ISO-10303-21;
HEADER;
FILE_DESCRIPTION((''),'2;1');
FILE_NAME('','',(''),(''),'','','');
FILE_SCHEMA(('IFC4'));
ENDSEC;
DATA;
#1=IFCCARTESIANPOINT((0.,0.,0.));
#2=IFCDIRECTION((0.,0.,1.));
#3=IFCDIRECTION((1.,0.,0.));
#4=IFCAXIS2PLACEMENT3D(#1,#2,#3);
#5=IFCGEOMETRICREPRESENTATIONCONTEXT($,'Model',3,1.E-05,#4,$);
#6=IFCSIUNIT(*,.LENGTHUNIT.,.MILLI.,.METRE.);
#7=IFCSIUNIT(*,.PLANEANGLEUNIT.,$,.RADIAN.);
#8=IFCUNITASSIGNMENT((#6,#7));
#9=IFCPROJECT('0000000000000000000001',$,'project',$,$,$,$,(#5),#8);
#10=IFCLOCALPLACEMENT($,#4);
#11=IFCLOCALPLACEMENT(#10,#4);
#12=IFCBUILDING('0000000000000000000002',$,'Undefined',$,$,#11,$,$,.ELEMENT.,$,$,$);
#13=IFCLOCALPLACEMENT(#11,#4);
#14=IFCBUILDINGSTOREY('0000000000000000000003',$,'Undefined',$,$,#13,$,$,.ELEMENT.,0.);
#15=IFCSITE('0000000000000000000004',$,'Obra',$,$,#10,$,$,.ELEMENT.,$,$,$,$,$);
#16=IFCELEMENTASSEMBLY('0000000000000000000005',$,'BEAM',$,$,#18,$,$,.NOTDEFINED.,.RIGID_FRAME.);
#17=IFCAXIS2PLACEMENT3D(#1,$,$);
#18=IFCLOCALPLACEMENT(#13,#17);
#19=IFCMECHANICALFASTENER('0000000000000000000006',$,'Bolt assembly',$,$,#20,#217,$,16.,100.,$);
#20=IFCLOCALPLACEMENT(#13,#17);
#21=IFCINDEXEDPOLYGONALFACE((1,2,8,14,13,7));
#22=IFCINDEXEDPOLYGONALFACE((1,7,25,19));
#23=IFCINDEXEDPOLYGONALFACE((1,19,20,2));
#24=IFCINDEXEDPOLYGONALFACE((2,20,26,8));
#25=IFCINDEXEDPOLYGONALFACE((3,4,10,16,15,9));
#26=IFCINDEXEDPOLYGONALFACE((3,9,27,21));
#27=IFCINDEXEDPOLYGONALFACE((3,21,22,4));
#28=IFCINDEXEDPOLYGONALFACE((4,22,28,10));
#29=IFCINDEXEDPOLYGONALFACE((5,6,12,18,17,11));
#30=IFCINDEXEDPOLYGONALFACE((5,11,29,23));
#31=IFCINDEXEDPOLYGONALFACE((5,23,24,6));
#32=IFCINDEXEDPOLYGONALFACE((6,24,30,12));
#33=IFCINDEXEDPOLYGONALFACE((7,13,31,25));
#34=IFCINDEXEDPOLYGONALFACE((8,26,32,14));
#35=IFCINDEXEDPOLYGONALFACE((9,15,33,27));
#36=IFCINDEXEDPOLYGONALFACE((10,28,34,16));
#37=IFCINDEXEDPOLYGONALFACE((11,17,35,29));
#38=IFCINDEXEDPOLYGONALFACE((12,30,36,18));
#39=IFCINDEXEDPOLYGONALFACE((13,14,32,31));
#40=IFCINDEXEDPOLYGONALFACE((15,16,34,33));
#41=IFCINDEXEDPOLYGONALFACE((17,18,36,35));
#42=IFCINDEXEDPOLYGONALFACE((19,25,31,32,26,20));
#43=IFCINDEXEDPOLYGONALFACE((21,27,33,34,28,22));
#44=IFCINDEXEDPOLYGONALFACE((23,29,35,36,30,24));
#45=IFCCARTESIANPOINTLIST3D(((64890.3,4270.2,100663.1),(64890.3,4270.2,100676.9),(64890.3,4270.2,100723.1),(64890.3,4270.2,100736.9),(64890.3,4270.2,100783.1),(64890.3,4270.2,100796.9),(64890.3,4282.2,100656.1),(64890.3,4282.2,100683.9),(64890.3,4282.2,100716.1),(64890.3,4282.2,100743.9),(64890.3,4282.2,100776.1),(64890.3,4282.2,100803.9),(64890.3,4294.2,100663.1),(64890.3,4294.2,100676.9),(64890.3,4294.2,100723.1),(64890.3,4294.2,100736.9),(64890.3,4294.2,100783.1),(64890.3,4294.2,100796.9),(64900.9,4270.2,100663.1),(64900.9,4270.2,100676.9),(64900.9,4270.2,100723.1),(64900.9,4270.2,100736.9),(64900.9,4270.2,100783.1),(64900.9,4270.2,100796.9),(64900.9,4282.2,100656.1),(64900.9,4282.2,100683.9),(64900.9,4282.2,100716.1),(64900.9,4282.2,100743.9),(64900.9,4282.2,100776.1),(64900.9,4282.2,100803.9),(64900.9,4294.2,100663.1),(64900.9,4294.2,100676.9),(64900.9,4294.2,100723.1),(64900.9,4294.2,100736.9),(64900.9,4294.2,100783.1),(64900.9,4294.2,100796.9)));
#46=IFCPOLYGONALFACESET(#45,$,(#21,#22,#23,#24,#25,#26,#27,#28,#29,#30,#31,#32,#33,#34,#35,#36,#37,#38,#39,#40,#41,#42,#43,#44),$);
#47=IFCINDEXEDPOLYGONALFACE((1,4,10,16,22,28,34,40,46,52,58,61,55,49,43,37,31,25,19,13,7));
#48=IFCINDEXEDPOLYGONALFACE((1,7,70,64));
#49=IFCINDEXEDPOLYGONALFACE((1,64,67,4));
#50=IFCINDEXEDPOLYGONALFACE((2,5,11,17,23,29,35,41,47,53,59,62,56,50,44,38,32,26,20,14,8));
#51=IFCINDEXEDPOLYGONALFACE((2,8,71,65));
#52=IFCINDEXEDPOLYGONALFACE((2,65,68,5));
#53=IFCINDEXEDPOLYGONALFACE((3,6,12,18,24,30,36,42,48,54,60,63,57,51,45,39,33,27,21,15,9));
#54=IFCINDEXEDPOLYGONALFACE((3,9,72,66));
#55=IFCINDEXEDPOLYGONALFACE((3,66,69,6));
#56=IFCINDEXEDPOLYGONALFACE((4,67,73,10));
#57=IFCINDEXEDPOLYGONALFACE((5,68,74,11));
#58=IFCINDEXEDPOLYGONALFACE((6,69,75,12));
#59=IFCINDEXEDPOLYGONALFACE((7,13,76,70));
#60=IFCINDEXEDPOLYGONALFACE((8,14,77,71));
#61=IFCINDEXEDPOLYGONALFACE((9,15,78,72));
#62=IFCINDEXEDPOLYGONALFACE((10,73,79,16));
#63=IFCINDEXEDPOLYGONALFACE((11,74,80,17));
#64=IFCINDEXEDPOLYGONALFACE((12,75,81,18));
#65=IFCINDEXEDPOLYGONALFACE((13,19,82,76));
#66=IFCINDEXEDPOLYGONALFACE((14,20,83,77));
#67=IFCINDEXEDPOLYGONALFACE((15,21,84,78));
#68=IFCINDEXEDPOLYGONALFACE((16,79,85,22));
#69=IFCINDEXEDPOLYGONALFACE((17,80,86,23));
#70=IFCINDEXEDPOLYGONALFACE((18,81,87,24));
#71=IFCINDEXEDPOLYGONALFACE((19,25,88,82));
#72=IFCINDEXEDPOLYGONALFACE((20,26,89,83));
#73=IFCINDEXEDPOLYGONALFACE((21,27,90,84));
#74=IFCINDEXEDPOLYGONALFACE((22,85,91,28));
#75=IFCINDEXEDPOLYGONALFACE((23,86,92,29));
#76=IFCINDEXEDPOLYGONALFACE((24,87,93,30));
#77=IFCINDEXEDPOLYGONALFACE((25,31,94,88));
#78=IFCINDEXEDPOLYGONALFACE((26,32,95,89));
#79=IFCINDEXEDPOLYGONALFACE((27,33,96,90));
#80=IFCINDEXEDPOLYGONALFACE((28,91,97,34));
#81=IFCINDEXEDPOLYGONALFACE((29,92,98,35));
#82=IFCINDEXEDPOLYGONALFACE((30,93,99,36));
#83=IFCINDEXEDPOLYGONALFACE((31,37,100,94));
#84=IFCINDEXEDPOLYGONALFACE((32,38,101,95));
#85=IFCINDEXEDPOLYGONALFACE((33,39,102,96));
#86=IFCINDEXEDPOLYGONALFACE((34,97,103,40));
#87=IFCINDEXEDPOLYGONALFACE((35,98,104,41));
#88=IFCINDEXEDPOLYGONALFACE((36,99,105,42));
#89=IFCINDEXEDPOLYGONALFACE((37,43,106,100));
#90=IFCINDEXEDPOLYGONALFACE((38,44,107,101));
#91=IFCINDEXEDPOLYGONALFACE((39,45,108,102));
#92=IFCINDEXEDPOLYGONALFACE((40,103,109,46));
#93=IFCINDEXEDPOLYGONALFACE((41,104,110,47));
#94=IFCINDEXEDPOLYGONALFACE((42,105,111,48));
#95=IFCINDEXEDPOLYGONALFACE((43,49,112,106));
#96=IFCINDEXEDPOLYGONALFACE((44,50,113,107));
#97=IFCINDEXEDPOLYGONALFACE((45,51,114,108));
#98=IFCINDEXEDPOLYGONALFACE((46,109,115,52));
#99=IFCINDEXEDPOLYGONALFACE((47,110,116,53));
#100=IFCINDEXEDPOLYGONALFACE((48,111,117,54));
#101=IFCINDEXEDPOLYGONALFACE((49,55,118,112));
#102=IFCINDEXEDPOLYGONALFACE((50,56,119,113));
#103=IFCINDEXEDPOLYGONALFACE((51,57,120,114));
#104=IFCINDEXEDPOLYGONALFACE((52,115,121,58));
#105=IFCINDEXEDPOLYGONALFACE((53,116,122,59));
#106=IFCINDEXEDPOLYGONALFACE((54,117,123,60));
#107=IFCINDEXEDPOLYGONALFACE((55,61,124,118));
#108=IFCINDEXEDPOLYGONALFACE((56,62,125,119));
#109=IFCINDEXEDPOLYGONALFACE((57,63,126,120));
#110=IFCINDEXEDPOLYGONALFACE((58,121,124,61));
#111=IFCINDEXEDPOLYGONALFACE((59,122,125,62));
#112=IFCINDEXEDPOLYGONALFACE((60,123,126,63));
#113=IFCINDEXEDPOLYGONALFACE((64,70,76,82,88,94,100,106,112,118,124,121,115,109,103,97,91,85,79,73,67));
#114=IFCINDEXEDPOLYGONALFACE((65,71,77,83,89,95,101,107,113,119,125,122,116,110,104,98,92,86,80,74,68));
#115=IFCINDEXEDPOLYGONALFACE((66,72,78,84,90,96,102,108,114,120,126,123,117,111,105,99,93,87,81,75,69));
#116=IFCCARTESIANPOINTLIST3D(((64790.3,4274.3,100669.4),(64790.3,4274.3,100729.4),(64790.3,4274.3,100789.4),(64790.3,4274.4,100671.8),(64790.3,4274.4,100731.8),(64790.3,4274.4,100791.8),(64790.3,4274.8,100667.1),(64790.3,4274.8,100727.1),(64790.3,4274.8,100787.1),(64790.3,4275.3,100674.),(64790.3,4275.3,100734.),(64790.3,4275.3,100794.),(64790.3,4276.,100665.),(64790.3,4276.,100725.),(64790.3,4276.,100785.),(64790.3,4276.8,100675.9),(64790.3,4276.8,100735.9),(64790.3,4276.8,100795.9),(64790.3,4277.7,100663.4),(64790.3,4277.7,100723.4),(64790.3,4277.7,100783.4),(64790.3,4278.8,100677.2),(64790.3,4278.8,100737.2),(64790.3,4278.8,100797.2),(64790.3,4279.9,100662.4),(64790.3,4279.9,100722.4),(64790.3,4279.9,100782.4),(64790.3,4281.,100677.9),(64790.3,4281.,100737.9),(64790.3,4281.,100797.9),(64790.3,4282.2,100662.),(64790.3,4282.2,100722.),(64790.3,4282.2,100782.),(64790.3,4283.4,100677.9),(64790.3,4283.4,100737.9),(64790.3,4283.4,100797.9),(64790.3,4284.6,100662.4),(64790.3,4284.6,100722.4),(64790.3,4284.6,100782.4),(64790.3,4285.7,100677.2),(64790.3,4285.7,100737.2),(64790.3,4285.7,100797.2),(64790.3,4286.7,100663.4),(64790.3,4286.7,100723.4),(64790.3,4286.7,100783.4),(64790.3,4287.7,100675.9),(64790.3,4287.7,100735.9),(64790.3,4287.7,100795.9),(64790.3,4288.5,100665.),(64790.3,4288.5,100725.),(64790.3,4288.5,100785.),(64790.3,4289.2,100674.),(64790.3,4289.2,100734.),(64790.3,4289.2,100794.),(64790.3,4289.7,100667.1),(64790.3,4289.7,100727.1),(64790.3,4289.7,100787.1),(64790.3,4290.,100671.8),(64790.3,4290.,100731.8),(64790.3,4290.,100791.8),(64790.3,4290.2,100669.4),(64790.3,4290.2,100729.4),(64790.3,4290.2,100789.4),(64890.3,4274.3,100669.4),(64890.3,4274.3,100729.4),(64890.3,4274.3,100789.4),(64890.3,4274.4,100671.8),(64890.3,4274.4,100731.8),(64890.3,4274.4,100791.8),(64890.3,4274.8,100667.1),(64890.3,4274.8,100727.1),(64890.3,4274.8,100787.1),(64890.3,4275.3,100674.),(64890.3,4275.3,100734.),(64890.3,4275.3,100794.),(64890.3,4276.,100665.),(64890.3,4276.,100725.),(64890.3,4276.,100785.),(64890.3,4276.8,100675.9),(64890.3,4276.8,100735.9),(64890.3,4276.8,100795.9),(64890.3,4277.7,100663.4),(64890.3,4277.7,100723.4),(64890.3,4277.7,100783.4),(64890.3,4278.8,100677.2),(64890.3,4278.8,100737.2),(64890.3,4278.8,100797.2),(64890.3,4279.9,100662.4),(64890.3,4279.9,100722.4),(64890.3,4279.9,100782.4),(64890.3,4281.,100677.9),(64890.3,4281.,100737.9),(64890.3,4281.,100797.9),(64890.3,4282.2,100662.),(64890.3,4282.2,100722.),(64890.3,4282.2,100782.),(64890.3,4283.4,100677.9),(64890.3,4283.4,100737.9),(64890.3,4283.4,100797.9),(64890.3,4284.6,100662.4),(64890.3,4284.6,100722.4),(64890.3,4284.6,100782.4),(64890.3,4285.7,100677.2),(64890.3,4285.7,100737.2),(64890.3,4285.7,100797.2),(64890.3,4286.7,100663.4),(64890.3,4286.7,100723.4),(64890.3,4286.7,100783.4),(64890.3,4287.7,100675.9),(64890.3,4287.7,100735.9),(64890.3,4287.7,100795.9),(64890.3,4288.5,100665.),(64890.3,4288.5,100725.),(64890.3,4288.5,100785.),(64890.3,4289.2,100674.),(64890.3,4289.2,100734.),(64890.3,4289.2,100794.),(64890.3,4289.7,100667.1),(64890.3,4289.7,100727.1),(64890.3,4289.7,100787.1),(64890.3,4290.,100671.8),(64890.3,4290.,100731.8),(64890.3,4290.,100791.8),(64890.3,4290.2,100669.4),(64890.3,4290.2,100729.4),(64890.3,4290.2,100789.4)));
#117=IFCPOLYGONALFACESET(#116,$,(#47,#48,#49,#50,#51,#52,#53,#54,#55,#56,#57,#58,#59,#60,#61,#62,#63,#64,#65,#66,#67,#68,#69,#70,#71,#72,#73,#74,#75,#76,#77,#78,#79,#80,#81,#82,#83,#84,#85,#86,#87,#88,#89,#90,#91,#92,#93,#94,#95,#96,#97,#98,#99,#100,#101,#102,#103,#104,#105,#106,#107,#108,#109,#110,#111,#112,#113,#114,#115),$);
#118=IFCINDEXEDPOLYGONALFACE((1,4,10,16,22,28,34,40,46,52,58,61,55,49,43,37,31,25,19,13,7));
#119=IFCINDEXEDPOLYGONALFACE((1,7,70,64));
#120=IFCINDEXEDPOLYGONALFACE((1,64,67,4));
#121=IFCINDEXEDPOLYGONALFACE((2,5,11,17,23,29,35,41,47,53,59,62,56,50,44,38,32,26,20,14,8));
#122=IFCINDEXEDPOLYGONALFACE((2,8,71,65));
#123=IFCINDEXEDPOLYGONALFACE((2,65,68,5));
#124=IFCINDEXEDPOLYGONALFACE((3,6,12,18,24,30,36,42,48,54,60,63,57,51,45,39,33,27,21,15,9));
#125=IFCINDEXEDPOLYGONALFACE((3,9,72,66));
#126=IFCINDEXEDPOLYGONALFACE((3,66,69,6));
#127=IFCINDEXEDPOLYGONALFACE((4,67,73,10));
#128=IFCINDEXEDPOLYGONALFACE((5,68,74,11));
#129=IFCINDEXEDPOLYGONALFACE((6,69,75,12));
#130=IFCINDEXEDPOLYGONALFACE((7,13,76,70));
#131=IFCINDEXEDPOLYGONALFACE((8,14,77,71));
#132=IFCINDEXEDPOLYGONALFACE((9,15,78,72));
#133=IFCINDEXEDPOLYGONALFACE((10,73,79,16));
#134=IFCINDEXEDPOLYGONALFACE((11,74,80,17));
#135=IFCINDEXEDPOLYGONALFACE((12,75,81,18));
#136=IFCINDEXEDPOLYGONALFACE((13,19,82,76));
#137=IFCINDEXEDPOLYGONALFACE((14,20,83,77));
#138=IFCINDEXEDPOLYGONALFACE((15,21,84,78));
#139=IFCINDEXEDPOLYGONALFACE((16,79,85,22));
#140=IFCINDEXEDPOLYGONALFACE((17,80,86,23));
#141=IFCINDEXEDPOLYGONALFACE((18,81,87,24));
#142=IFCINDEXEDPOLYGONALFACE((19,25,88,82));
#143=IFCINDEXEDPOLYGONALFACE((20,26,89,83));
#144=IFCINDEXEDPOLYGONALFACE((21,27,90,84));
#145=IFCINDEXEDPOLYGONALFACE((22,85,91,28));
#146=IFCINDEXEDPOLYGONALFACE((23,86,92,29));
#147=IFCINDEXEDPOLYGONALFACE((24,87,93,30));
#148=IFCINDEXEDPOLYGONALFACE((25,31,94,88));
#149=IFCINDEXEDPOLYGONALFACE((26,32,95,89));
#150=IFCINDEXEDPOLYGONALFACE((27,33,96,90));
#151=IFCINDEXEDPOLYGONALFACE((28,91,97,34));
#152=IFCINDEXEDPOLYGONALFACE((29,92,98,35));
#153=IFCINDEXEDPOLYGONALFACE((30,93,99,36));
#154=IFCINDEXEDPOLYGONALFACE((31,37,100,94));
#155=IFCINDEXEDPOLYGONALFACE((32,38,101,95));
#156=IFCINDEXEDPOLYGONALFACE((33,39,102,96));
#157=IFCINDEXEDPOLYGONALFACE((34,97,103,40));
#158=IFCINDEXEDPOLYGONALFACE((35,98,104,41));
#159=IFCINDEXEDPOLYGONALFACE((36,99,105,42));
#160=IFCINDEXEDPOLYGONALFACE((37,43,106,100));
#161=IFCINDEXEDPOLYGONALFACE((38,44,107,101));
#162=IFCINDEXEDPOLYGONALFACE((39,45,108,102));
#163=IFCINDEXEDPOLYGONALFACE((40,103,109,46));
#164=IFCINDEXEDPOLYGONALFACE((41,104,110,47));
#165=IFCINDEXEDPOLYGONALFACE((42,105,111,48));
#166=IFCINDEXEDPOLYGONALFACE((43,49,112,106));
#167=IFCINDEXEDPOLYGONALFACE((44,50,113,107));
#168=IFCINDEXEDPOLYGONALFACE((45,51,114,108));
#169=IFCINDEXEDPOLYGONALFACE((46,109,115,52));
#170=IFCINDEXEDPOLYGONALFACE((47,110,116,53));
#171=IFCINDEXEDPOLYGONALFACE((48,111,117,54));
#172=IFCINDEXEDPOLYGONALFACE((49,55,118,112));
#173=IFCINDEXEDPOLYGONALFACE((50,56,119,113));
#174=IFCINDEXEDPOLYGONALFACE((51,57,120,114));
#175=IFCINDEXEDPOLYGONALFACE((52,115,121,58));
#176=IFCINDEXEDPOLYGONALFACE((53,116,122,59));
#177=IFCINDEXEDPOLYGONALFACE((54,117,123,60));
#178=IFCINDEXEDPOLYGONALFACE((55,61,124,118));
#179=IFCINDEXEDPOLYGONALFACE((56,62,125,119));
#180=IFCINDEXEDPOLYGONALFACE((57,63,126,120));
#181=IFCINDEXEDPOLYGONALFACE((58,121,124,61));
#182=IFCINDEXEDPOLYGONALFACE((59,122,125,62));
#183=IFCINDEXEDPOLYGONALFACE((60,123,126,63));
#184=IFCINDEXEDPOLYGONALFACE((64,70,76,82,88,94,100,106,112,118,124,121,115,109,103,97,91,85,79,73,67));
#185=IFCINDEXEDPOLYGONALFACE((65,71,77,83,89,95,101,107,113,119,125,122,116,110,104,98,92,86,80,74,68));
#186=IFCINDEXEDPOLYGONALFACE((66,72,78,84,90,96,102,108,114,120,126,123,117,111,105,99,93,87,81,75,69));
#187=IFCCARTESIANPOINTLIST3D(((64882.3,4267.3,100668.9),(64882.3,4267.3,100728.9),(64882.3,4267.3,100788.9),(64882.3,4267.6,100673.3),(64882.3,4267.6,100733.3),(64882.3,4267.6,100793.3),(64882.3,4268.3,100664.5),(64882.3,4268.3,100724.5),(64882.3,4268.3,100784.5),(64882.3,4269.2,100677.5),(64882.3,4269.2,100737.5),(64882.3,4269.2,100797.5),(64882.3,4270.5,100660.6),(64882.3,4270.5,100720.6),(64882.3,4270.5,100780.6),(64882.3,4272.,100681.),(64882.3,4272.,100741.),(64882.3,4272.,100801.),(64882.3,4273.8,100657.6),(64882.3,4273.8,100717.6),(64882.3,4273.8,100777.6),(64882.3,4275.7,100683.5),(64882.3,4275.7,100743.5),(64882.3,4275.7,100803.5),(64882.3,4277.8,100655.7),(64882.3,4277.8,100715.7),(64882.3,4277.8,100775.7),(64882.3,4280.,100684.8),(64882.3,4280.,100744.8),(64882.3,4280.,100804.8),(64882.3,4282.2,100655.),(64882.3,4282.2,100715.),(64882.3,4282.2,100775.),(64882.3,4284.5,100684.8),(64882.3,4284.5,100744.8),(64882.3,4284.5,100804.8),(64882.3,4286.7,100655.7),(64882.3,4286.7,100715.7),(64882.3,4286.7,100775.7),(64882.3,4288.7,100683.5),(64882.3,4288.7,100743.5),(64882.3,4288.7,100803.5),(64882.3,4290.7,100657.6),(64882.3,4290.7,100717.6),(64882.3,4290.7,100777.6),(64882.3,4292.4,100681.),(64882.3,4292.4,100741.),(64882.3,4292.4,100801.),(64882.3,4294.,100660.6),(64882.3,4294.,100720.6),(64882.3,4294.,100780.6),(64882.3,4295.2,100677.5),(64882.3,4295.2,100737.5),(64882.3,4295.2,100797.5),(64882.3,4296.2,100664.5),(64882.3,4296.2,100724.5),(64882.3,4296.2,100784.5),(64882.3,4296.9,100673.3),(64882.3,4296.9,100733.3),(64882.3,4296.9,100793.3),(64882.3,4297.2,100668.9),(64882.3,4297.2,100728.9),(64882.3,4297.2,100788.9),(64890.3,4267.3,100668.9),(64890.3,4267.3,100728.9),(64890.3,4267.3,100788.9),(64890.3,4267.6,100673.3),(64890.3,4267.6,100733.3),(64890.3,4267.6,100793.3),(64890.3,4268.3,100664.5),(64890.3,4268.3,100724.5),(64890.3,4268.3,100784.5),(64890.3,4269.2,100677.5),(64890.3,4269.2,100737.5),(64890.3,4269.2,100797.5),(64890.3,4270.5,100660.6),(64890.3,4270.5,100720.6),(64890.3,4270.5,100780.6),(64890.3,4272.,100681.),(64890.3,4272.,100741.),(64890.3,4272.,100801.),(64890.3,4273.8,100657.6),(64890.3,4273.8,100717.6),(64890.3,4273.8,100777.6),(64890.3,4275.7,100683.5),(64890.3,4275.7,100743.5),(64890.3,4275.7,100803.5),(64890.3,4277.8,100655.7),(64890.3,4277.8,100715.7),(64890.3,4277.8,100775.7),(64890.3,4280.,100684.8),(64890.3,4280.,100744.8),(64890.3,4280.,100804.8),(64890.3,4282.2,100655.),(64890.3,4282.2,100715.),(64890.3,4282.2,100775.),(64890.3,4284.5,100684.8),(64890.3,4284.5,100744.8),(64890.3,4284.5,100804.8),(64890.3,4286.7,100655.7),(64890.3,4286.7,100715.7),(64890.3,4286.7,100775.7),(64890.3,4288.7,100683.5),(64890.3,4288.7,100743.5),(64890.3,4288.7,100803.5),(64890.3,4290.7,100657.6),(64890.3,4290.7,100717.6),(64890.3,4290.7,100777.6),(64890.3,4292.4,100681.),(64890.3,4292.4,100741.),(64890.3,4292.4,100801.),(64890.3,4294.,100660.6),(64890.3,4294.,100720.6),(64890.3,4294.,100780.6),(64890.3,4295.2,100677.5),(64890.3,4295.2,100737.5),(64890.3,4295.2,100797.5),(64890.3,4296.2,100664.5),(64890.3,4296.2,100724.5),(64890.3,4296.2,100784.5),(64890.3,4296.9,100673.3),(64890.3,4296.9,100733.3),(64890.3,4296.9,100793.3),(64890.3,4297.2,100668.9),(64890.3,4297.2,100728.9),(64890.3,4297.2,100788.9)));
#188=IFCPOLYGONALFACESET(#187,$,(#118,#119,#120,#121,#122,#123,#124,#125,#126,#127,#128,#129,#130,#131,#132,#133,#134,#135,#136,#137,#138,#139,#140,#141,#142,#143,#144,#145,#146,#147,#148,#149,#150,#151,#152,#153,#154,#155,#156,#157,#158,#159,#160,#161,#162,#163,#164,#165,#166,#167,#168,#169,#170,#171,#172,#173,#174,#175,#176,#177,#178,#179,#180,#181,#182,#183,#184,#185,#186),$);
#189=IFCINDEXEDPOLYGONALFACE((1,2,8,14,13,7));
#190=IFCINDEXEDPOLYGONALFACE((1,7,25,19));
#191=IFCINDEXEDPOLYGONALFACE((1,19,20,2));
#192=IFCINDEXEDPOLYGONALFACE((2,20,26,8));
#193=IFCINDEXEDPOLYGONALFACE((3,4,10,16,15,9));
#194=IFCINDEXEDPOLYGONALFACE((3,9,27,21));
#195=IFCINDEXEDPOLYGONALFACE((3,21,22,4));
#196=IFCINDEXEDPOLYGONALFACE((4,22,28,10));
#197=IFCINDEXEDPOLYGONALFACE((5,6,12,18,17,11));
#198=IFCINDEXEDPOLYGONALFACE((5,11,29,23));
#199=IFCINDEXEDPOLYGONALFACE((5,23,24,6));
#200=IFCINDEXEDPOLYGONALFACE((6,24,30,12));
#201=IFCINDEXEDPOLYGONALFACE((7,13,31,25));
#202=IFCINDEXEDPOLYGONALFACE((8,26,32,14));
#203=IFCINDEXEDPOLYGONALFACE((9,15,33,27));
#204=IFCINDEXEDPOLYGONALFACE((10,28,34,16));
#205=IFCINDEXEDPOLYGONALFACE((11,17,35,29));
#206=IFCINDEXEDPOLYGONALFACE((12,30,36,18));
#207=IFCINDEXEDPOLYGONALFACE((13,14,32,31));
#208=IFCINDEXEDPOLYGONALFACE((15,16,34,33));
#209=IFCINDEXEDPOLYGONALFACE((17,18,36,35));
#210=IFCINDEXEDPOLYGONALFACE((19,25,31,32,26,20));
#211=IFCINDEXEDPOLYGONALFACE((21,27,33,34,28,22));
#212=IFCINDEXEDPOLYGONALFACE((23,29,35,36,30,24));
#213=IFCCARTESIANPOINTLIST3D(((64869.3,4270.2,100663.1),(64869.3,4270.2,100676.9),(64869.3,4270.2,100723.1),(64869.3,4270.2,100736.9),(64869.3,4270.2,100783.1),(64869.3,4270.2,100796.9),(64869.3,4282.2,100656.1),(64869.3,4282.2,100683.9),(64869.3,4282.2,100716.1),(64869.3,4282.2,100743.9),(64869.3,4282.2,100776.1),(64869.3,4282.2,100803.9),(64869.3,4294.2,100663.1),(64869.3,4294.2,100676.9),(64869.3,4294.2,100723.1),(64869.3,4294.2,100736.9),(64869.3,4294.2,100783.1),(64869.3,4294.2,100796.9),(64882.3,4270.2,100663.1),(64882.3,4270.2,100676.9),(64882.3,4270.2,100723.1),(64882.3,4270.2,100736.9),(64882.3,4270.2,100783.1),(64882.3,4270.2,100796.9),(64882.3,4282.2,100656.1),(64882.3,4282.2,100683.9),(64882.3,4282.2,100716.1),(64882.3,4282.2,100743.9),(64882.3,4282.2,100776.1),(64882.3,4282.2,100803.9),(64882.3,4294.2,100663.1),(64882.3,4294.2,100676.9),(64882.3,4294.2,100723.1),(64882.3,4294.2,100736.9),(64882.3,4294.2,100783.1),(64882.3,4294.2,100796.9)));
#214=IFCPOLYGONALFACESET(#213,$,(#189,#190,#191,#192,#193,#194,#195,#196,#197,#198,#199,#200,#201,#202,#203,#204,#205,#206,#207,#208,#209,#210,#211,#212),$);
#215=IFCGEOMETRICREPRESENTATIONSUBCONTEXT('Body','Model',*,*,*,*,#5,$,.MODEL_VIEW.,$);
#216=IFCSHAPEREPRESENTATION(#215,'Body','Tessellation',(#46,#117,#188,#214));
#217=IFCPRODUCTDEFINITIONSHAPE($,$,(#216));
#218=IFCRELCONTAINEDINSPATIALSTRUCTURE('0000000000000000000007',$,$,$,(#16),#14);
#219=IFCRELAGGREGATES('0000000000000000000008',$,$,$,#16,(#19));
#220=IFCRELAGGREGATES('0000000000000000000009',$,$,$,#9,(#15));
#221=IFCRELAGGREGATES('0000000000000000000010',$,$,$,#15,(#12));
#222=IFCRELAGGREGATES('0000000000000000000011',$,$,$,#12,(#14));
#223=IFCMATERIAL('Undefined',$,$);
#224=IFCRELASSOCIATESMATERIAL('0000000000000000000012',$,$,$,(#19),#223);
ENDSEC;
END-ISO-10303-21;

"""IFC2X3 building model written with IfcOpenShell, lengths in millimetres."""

from ifc_helpers import new_model, si_unit, frame, origin_with_axes, origin_2d_with_axis, place, context, subcontext, project, spatial, polyline, circle, outline, extrude, source, transform, mapped, material, element, aggregate, save


model = new_model("IFC2X3")

# Units and contexts
model_context = context("Model", 3, precision=1e-05, world=origin_with_axes())
body_context = subcontext(model_context, "Body", "Model", "MODEL_VIEW")
ifc_project = project(units=[si_unit("LENGTHUNIT", "METRE", prefix="MILLI"), si_unit("PLANEANGLEUNIT", "RADIAN")], contexts=[model_context])

# Site, building, storey
site_placement = place(None, origin_with_axes())
site = spatial("IfcSite", under=ifc_project, at=site_placement, Name="Obra", CompositionType="ELEMENT")
building_placement = place(site_placement, origin_with_axes())
building = spatial("IfcBuilding", under=site, at=building_placement, Name="Undefined", CompositionType="ELEMENT")
storey_placement = place(building_placement, origin_with_axes())
storey = spatial("IfcBuildingStorey", under=building, at=storey_placement, Name="Undefined", CompositionType="ELEMENT", Elevation=0.0)

# Shared definitions
ifc_material_1 = material(Name="Undefined")

# Element assembly, mechanical fastener
assembly_1_placement = place(storey_placement, origin_with_axes())
assembly_1 = element("IfcElementAssembly", 1, at=assembly_1_placement, inside=storey, Name="BEAM", AssemblyPlace="NOTDEFINED", PredefinedType="RIGID_FRAME")
shared_shape_1 = source(origin_with_axes(), body_context, "Body", "SweptSolid", [
    extrude(outline(polyline([(13.9, 0.0), (6.9, 12.0), (-6.9, 12.0), (-13.9, 0.0), (-6.9, -12.0), (6.9, -12.0), (13.9, 0.0)])), frame((0.0, -10.6, 0.0), z_axis=(0.0, 1.0, 0.0), x_axis=(1.0, 0.0, 0.0)), (0.0, 0.0, 1.0), 10.6),
    extrude(circle(Radius=8.0, at=origin_2d_with_axis()), frame((0.0, 0.0, 0.0), z_axis=(0.0, 1.0, 0.0), x_axis=(1.0, 0.0, 0.0)), (0.0, 0.0, 1.0), 100.0),
    extrude(circle(Radius=15.0, at=origin_2d_with_axis()), frame((0.0, 0.0, 0.0), z_axis=(0.0, 1.0, 0.0), x_axis=(1.0, 0.0, 0.0)), (0.0, 0.0, 1.0), 8.0),
    extrude(outline(polyline([(13.9, 0.0), (6.9, 12.0), (-6.9, 12.0), (-13.9, 0.0), (-6.9, -12.0), (6.9, -12.0), (13.9, 0.0)])), frame((0.0, 8.0, 0.0), z_axis=(0.0, 1.0, 0.0), x_axis=(1.0, 0.0, 0.0)), (0.0, 0.0, 1.0), 13.0),
])
mechanical_fastener_1_placement = place(assembly_1_placement, frame((64890.3, 4232.2, 100850.0), z_axis=(0.0, 1.0, 0.0), x_axis=(0.0, 0.0, -1.0)))
mechanical_fastener_1 = element("IfcMechanicalFastener", 2, at=mechanical_fastener_1_placement, material=ifc_material_1, Name="Bolt assembly", NominalDiameter=16.0, NominalLength=100.0, context=body_context, shape_type="MappedRepresentation", body=[
    mapped(shared_shape_1, transform((60.0, 0.0, 50.0))),
    mapped(shared_shape_1, transform((120.0, 0.0, 50.0))),
    mapped(shared_shape_1, transform((180.0, 0.0, 50.0))),
])
aggregate(assembly_1, [mechanical_fastener_1])

save(model, "model.ifc")
